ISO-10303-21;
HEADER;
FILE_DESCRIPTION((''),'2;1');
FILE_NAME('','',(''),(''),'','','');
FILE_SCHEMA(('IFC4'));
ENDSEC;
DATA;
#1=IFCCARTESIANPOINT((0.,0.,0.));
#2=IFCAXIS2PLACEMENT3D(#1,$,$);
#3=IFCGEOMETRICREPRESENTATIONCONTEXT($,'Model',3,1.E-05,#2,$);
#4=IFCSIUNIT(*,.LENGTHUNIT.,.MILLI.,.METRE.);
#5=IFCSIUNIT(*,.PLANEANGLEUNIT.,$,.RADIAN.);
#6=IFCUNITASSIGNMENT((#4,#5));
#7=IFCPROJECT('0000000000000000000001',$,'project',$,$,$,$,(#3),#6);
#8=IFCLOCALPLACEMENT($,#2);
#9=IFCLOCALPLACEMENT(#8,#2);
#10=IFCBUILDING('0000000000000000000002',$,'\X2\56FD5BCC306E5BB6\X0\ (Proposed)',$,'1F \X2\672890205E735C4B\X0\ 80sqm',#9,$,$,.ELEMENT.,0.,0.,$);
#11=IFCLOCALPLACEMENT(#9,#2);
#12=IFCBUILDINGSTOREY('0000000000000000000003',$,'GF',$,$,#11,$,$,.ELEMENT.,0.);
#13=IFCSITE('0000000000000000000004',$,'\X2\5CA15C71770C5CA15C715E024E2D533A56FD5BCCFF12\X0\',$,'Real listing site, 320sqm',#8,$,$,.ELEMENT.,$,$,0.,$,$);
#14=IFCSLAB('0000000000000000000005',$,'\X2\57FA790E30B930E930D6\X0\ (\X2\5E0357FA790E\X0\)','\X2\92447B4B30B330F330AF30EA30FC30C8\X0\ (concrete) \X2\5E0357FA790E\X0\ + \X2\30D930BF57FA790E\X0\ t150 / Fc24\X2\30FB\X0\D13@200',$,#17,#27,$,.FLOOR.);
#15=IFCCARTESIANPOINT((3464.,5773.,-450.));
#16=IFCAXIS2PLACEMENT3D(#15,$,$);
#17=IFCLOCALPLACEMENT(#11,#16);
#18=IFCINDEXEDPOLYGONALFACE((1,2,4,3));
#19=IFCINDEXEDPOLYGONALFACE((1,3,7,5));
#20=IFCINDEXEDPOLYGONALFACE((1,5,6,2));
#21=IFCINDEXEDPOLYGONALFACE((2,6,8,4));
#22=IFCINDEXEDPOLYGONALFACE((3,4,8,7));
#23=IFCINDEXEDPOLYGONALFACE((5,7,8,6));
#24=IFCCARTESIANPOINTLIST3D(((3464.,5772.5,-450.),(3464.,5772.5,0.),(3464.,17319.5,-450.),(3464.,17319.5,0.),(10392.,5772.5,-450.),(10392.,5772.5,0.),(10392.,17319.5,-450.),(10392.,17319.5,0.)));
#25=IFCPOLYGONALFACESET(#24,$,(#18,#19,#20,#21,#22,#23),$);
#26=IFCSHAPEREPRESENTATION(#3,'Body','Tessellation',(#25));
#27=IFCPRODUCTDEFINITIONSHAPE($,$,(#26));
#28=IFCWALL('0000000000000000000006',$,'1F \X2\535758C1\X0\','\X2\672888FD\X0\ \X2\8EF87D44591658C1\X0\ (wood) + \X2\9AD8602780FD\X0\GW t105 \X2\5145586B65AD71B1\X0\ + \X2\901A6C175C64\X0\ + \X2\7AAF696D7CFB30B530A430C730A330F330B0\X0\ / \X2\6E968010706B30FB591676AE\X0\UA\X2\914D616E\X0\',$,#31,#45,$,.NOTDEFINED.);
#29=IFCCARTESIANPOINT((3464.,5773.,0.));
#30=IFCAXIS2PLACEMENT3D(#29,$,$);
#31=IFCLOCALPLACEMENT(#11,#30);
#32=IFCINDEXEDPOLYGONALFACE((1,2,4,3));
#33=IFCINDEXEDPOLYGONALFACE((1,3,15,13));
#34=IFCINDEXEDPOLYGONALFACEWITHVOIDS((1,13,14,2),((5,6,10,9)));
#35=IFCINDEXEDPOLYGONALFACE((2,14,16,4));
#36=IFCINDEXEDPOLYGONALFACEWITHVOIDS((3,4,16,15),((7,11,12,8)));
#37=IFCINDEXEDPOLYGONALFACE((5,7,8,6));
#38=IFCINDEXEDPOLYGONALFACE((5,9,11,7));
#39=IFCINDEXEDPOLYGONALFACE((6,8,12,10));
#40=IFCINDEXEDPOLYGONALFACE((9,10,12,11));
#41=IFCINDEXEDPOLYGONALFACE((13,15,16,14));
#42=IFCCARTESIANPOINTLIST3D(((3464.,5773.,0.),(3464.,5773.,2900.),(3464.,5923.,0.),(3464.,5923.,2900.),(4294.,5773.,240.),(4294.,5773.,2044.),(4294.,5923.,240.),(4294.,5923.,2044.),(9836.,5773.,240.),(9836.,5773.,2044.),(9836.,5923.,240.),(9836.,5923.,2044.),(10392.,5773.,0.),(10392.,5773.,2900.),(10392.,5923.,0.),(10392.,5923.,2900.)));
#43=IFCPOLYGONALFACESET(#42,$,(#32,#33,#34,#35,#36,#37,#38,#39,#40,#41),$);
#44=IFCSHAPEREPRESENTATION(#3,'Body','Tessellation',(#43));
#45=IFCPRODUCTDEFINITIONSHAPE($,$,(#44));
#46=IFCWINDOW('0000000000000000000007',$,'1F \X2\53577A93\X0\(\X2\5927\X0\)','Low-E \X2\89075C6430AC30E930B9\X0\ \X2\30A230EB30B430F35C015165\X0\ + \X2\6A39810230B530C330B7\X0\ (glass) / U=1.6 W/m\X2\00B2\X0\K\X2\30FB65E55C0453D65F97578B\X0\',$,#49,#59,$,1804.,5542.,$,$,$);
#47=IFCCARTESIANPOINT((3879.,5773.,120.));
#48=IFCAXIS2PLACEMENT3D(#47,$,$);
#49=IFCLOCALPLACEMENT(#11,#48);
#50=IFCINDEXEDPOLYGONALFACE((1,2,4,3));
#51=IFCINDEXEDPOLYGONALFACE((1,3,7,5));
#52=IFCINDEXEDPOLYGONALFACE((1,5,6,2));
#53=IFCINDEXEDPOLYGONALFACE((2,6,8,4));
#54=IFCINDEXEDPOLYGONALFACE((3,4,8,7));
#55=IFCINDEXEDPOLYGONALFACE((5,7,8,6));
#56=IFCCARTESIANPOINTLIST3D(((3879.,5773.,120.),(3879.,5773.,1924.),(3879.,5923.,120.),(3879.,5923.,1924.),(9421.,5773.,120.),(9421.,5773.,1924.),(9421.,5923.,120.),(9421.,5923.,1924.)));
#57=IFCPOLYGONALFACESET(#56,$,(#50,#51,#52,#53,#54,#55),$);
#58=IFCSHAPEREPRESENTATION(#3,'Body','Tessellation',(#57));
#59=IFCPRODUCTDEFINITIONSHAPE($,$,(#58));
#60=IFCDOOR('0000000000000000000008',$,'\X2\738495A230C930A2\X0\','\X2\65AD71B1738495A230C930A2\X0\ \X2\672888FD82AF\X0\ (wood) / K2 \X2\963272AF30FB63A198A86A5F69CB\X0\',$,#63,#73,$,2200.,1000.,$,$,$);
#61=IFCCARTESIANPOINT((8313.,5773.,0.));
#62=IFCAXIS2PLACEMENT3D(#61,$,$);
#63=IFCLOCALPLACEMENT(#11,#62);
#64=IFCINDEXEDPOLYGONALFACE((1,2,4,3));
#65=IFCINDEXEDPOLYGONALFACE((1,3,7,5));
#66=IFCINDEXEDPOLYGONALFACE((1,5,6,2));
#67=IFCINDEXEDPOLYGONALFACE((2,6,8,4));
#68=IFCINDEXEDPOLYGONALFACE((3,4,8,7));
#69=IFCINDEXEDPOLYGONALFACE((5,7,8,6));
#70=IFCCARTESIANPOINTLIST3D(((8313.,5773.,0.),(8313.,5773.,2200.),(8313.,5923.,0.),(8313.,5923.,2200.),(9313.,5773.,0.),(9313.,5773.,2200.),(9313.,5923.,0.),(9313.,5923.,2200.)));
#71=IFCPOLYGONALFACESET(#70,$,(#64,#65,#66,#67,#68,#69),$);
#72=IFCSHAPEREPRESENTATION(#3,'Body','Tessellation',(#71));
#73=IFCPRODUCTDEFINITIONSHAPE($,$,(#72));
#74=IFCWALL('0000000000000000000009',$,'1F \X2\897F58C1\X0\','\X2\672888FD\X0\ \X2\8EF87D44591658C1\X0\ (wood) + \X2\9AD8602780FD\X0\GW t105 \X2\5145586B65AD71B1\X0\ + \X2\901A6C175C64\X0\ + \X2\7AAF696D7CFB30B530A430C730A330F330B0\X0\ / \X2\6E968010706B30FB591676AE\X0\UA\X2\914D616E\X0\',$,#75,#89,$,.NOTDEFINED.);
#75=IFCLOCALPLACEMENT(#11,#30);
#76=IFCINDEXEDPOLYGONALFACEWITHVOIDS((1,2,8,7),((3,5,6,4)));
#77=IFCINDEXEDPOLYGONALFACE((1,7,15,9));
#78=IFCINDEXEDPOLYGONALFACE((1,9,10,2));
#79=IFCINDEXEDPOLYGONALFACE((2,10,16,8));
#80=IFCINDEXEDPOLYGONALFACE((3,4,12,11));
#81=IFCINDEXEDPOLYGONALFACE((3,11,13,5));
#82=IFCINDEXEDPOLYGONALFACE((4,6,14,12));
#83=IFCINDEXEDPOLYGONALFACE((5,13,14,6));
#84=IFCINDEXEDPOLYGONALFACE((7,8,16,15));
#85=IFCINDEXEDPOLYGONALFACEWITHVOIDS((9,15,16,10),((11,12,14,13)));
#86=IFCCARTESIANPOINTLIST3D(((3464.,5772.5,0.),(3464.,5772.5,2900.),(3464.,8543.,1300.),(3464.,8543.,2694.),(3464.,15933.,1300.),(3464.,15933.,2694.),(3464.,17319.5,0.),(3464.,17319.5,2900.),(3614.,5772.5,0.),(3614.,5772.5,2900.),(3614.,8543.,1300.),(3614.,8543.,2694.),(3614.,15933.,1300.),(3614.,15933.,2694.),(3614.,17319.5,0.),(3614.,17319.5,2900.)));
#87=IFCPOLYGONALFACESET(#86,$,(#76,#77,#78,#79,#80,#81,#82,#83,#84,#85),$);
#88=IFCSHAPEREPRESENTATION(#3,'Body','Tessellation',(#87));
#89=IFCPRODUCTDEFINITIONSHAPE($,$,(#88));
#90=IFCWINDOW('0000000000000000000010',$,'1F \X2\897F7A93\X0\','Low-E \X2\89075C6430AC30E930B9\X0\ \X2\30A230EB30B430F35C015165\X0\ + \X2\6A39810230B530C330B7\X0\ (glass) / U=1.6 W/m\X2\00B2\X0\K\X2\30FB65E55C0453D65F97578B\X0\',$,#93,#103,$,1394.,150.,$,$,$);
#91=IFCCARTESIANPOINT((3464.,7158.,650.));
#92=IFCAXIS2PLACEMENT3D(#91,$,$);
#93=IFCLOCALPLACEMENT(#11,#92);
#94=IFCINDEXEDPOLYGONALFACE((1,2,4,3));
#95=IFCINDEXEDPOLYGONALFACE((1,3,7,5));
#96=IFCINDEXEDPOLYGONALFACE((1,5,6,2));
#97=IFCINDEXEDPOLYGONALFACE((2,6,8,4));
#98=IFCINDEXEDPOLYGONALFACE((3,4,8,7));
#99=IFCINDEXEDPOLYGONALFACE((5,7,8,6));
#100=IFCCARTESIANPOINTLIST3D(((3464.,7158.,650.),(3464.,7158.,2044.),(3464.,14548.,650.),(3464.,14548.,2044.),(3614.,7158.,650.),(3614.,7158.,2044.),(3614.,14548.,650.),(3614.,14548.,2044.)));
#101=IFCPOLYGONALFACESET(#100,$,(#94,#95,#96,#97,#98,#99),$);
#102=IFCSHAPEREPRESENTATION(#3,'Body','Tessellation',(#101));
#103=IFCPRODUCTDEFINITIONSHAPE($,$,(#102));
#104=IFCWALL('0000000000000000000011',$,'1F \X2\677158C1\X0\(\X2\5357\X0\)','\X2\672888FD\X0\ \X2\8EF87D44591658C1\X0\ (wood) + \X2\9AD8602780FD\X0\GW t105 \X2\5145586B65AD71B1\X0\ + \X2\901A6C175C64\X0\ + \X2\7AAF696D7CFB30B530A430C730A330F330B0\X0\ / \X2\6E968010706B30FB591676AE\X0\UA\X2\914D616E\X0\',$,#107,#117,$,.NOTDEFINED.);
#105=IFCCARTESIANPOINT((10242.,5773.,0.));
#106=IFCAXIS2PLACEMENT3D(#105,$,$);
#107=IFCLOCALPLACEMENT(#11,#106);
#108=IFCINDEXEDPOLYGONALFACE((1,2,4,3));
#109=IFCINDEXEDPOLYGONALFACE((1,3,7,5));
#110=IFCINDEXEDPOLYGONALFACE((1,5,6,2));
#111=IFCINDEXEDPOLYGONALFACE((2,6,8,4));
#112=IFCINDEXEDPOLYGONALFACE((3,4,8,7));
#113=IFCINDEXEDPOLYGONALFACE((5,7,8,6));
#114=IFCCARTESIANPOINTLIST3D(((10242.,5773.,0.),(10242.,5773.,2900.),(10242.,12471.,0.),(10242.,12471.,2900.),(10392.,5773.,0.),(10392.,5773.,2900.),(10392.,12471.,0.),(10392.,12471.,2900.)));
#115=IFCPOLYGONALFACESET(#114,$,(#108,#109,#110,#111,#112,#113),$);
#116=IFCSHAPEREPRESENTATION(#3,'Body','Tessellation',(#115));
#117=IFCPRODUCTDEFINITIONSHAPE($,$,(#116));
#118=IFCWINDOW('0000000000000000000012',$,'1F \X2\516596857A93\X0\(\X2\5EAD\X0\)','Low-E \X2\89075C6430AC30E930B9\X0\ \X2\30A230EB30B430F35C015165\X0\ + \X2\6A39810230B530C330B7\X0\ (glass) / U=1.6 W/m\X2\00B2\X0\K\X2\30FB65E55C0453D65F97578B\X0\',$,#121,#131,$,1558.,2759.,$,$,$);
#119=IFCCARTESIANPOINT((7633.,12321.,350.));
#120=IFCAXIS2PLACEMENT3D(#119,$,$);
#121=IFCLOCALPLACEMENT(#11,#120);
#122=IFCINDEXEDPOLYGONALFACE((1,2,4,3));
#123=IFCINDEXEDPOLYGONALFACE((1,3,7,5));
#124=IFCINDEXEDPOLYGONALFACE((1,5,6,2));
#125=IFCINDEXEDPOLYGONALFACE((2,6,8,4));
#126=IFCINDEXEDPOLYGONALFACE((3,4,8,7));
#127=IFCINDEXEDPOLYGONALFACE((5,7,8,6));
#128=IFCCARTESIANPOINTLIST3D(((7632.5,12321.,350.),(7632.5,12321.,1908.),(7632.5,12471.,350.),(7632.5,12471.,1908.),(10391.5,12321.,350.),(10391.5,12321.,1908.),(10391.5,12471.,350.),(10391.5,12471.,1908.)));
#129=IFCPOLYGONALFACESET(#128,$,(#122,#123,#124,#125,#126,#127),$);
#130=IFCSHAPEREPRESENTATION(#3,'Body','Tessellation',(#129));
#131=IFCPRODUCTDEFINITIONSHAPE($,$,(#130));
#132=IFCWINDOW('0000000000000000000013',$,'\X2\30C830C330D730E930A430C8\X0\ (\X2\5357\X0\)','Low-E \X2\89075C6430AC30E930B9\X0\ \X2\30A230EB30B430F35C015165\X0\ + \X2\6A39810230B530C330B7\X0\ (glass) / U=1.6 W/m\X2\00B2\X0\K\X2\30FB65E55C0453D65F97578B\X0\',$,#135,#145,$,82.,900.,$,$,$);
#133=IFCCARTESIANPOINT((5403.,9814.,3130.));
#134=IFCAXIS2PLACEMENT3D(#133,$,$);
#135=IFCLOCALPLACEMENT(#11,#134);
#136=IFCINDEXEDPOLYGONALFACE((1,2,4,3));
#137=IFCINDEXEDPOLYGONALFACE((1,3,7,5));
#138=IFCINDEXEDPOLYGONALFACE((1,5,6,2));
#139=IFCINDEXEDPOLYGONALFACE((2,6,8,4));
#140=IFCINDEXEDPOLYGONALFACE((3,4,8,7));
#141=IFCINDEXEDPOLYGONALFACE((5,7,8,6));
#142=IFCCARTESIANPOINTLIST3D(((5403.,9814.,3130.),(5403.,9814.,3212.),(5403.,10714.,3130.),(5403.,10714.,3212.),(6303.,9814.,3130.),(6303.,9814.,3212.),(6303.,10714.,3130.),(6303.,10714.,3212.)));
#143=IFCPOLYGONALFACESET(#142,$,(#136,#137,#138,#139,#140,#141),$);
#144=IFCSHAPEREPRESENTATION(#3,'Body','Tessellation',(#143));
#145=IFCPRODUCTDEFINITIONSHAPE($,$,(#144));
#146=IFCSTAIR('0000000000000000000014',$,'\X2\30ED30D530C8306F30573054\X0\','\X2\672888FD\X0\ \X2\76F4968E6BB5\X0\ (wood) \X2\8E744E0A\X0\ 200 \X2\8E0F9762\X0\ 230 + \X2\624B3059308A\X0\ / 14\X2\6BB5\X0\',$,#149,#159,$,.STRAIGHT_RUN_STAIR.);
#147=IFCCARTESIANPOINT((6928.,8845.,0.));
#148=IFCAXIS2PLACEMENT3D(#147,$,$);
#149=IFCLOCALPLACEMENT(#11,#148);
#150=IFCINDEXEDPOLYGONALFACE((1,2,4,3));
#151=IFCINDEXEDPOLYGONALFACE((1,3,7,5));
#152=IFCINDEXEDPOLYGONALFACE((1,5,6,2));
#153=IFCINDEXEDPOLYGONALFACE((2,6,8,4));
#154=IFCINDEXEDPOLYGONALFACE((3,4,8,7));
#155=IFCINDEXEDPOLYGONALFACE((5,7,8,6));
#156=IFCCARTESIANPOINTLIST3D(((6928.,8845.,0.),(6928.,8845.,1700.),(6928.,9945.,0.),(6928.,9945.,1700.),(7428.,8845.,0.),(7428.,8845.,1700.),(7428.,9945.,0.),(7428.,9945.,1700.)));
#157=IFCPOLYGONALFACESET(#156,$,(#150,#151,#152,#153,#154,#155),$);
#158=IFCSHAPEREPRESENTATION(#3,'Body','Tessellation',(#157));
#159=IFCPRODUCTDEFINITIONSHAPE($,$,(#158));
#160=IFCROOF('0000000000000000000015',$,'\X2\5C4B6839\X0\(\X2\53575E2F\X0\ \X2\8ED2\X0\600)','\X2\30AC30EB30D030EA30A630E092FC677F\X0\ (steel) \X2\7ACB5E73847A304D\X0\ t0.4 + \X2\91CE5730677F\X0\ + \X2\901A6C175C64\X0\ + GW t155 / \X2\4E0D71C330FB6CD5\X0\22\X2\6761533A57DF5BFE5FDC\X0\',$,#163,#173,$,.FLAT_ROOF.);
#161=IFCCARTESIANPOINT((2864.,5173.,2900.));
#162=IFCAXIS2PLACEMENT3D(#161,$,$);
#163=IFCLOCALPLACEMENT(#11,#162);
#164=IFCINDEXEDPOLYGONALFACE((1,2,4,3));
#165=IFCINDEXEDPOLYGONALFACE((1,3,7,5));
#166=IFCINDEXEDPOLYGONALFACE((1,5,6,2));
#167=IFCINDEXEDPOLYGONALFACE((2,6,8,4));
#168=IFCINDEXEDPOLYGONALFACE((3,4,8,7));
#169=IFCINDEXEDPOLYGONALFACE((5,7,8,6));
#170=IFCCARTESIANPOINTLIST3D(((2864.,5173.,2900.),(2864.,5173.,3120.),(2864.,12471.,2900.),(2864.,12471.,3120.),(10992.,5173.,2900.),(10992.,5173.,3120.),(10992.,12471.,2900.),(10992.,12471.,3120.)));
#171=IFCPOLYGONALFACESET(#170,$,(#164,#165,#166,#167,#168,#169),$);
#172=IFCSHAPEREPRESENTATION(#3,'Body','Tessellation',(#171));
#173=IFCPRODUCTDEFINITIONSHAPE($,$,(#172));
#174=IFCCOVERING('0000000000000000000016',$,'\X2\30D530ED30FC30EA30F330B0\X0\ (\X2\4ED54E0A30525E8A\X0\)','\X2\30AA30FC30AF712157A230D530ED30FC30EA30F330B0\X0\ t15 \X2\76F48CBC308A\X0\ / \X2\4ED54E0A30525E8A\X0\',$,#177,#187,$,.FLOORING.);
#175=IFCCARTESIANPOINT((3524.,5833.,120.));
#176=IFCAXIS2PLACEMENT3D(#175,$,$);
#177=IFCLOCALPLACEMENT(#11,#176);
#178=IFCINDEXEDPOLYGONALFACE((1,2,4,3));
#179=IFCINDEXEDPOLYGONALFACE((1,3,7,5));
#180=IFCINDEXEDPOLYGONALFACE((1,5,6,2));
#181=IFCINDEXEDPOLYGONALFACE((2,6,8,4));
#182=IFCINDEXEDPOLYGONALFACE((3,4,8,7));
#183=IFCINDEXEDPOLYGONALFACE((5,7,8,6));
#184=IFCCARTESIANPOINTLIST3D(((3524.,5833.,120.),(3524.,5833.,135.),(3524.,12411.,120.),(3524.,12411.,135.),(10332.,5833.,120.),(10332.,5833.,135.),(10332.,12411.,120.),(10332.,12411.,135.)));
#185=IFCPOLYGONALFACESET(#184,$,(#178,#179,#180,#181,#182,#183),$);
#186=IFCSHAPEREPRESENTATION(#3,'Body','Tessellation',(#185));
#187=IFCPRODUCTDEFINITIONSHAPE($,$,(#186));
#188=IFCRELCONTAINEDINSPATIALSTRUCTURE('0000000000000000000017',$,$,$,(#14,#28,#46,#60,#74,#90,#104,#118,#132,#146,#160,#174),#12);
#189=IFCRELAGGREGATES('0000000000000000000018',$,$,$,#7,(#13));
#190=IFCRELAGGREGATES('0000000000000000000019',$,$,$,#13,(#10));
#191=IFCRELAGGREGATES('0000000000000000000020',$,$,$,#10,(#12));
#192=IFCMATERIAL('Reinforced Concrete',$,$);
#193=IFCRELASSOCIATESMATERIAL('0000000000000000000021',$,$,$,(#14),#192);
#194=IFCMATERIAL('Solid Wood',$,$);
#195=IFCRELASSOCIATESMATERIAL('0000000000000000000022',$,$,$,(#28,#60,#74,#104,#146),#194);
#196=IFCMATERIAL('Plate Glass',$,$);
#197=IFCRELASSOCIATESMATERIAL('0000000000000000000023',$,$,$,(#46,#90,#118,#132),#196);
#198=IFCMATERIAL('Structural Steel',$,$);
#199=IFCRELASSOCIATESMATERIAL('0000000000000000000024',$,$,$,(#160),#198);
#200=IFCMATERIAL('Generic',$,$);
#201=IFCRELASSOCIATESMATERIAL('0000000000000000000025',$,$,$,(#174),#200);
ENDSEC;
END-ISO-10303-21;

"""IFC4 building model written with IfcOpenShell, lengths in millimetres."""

from ifc_helpers import new_model, si_unit, frame, frame_2d, origin, place, context, project, spatial, rectangle, extrude, material, element, fill, save


model = new_model("IFC4")

# Units and contexts
model_context = context("Model", 3, precision=1e-05, world=origin())
ifc_project = project(units=[si_unit("LENGTHUNIT", "METRE", prefix="MILLI"), si_unit("PLANEANGLEUNIT", "RADIAN")], contexts=[model_context])

# Site, building, storey
site_placement = place(None, origin())
site = spatial("IfcSite", under=ifc_project, at=site_placement, Name="岡山県岡山市中区国富２", ObjectType="Real listing site, 320sqm", CompositionType="ELEMENT", RefElevation=0.0)
building_placement = place(site_placement, origin())
building = spatial("IfcBuilding", under=site, at=building_placement, Name="国富の家 (Proposed)", ObjectType="1F 木造平屋 80sqm", CompositionType="ELEMENT", ElevationOfRefHeight=0.0, ElevationOfTerrain=0.0)
storey_placement = place(building_placement, origin())
storey = spatial("IfcBuildingStorey", under=building, at=storey_placement, Name="GF", CompositionType="ELEMENT", Elevation=0.0)

# Slab
ifc_material_1 = material(Name="Reinforced Concrete")
slab_1_placement = place(storey_placement, frame((3464.0, 5773.0, -450.0)))
element("IfcSlab", 1, at=slab_1_placement, inside=storey, material=ifc_material_1, Name="基礎スラブ (布基礎)", Description="鉄筋コンクリート (concrete) 布基礎 + ベタ基礎 t150 / Fc24・D13@200", PredefinedType="FLOOR", context=model_context, shape_type="SweptSolid", body=[
    extrude(rectangle(XDim=6928.0, YDim=11547.0, at=frame_2d((3464.0, 5773.0))), frame((3464.0, 5773.0, -450.0)), (0.0, 0.0, 1.0), 450.0),
])
ifc_material_2 = material(Name="Solid Wood")

# Wall, openings, window, door
wall_1_placement = place(storey_placement, frame((3464.0, 5773.0, 0.0)))
wall_1 = element("IfcWall", 2, at=wall_1_placement, inside=storey, material=ifc_material_2, Name="1F 南壁", Description="木製 軸組外壁 (wood) + 高性能GW t105 充填断熱 + 通気層 + 窯業系サイディング / 準耐火・外皮UA配慮", PredefinedType="NOTDEFINED", context=model_context, shape_type="SweptSolid", body=[
    extrude(rectangle(XDim=6928.0, YDim=150.0, at=frame_2d((3464.0, 75.0))), frame((3464.0, 5773.0, 0.0)), (0.0, 0.0, 1.0), 2900.0),
])
opening_1_placement = place(storey_placement, frame((3879.0, 5773.0, 120.0)))
opening_1 = element("IfcOpeningElement", 3, at=opening_1_placement, cuts=wall_1, PredefinedType="NOTDEFINED", context=model_context, shape_type="SweptSolid", body=[
    extrude(rectangle(XDim=5542.0, YDim=150.0, at=frame_2d((2771.0, 75.0))), frame((3879.0, 5773.0, 120.0)), (0.0, 0.0, 1.0), 1804.0),
])
opening_2_placement = place(storey_placement, frame((8313.0, 5773.0, 0.0)))
opening_2 = element("IfcOpeningElement", 4, at=opening_2_placement, cuts=wall_1, PredefinedType="NOTDEFINED", context=model_context, shape_type="SweptSolid", body=[
    extrude(rectangle(XDim=1000.0, YDim=150.0, at=frame_2d((500.0, 75.0))), frame((8313.0, 5773.0, 0.0)), (0.0, 0.0, 1.0), 2200.0),
])
ifc_material_3 = material(Name="Plate Glass")
window_1_placement = place(storey_placement, frame((3879.0, 5773.0, 120.0)))
window_1 = element("IfcWindow", 5, at=window_1_placement, inside=storey, material=ifc_material_3, Name="1F 南窓(大)", Description="Low-E 複層ガラス アルゴン封入 + 樹脂サッシ (glass) / U=1.6 W/m²K・日射取得型", OverallHeight=1804.0, OverallWidth=5542.0, context=model_context, shape_type="SweptSolid", body=[
    extrude(rectangle(XDim=5542.0, YDim=150.0, at=frame_2d((2771.0, 75.0))), frame((3879.0, 5773.0, 120.0)), (0.0, 0.0, 1.0), 1804.0),
])
fill(opening_1, window_1)
door_1_placement = place(storey_placement, frame((8313.0, 5773.0, 0.0)))
door_1 = element("IfcDoor", 6, at=door_1_placement, inside=storey, material=ifc_material_2, Name="玄関ドア", Description="断熱玄関ドア 木製芯 (wood) / K2 防犯・採風機構", OverallHeight=2200.0, OverallWidth=1000.0, context=model_context, shape_type="SweptSolid", body=[
    extrude(rectangle(XDim=1000.0, YDim=150.0, at=frame_2d((500.0, 75.0))), frame((8313.0, 5773.0, 0.0)), (0.0, 0.0, 1.0), 2200.0),
])
fill(opening_2, door_1)

# Walls, openings, windows
wall_2_placement = place(storey_placement, frame((3464.0, 5773.0, 0.0)))
wall_2 = element("IfcWall", 7, at=wall_2_placement, inside=storey, material=ifc_material_2, Name="1F 西壁", Description="木製 軸組外壁 (wood) + 高性能GW t105 充填断熱 + 通気層 + 窯業系サイディング / 準耐火・外皮UA配慮", PredefinedType="NOTDEFINED", context=model_context, shape_type="SweptSolid", body=[
    extrude(rectangle(XDim=150.0, YDim=11547.0, at=frame_2d((75.0, 5773.0))), frame((3464.0, 5773.0, 0.0)), (0.0, 0.0, 1.0), 2900.0),
])
opening_3_placement = place(storey_placement, frame((3464.0, 7158.0, 650.0)))
opening_3 = element("IfcOpeningElement", 8, at=opening_3_placement, cuts=wall_2, PredefinedType="NOTDEFINED", context=model_context, shape_type="SweptSolid", body=[
    extrude(rectangle(XDim=150.0, YDim=7390.0, at=frame_2d((75.0, 3695.0))), frame((3464.0, 7158.0, 650.0)), (0.0, 0.0, 1.0), 1394.0),
])
window_2_placement = place(storey_placement, frame((3464.0, 7158.0, 650.0)))
window_2 = element("IfcWindow", 9, at=window_2_placement, inside=storey, material=ifc_material_3, Name="1F 西窓", Description="Low-E 複層ガラス アルゴン封入 + 樹脂サッシ (glass) / U=1.6 W/m²K・日射取得型", OverallHeight=1394.0, OverallWidth=150.0, context=model_context, shape_type="SweptSolid", body=[
    extrude(rectangle(XDim=150.0, YDim=7390.0, at=frame_2d((75.0, 3695.0))), frame((3464.0, 7158.0, 650.0)), (0.0, 0.0, 1.0), 1394.0),
])
fill(opening_3, window_2)
wall_3_placement = place(storey_placement, frame((10242.0, 5773.0, 0.0)))
wall_3 = element("IfcWall", 10, at=wall_3_placement, inside=storey, material=ifc_material_2, Name="1F 東壁(南)", Description="木製 軸組外壁 (wood) + 高性能GW t105 充填断熱 + 通気層 + 窯業系サイディング / 準耐火・外皮UA配慮", PredefinedType="NOTDEFINED", context=model_context, shape_type="SweptSolid", body=[
    extrude(rectangle(XDim=150.0, YDim=6698.0, at=frame_2d((75.0, 3349.0))), frame((10242.0, 5773.0, 0.0)), (0.0, 0.0, 1.0), 2900.0),
])
opening_4_placement = place(storey_placement, frame((7633.0, 12321.0, 350.0)))
opening_4 = element("IfcOpeningElement", 11, at=opening_4_placement, cuts=wall_3, PredefinedType="NOTDEFINED", context=model_context, shape_type="SweptSolid", body=[
    extrude(rectangle(XDim=2759.0, YDim=150.0, at=frame_2d((1379.0, 75.0))), frame((7633.0, 12321.0, 350.0)), (0.0, 0.0, 1.0), 1558.0),
])
window_3_placement = place(storey_placement, frame((7633.0, 12321.0, 350.0)))
window_3 = element("IfcWindow", 12, at=window_3_placement, inside=storey, material=ifc_material_3, Name="1F 入隅窓(庭)", Description="Low-E 複層ガラス アルゴン封入 + 樹脂サッシ (glass) / U=1.6 W/m²K・日射取得型", OverallHeight=1558.0, OverallWidth=2759.0, context=model_context, shape_type="SweptSolid", body=[
    extrude(rectangle(XDim=2759.0, YDim=150.0, at=frame_2d((1379.0, 75.0))), frame((7633.0, 12321.0, 350.0)), (0.0, 0.0, 1.0), 1558.0),
])
fill(opening_4, window_3)

# Window
window_4_placement = place(storey_placement, frame((5403.0, 9814.0, 3130.0)))
element("IfcWindow", 13, at=window_4_placement, inside=storey, material=ifc_material_3, Name="トップライト (南)", Description="Low-E 複層ガラス アルゴン封入 + 樹脂サッシ (glass) / U=1.6 W/m²K・日射取得型", OverallHeight=82.0, OverallWidth=900.0, context=model_context, shape_type="SweptSolid", body=[
    extrude(rectangle(XDim=900.0, YDim=900.0, at=frame_2d((450.0, 450.0))), frame((5403.0, 9814.0, 3130.0)), (0.0, 0.0, 1.0), 82.0),
])

# Stair
stair_placement = place(storey_placement, frame((6928.0, 8845.0, 0.0)))
element("IfcStair", 14, at=stair_placement, inside=storey, material=ifc_material_2, Name="ロフトはしご", Description="木製 直階段 (wood) 蹴上 200 踏面 230 + 手すり / 14段", PredefinedType="STRAIGHT_RUN_STAIR", context=model_context, shape_type="SweptSolid", body=[
    extrude(rectangle(XDim=500.0, YDim=1100.0, at=frame_2d((250.0, 550.0))), frame((6928.0, 8845.0, 0.0)), (0.0, 0.0, 1.0), 1700.0),
])

# Roof
ifc_material_4 = material(Name="Structural Steel")
roof_placement = place(storey_placement, frame((2864.0, 5173.0, 2900.0)))
element("IfcRoof", 15, at=roof_placement, inside=storey, material=ifc_material_4, Name="屋根(南帯 軒600)", Description="ガルバリウム鋼板 (steel) 立平葺き t0.4 + 野地板 + 通気層 + GW t155 / 不燃・法22条区域対応", PredefinedType="FLAT_ROOF", context=model_context, shape_type="SweptSolid", body=[
    extrude(rectangle(XDim=8128.0, YDim=7298.0, at=frame_2d((4064.0, 3649.0))), frame((2864.0, 5173.0, 2900.0)), (0.0, 0.0, 1.0), 220.0),
])

# Covering
ifc_material_5 = material(Name="Generic")
covering_placement = place(storey_placement, frame((3524.0, 5833.0, 120.0)))
element("IfcCovering", 16, at=covering_placement, inside=storey, material=ifc_material_5, Name="フローリング (仕上げ床)", Description="オーク無垢フローリング t15 直貼り / 仕上げ床", PredefinedType="FLOORING", context=model_context, shape_type="SweptSolid", body=[
    extrude(rectangle(XDim=6808.0, YDim=6578.0, at=frame_2d((3404.0, 3289.0))), frame((3524.0, 5833.0, 120.0)), (0.0, 0.0, 1.0), 15.0),
])

save(model, "model.ifc")
